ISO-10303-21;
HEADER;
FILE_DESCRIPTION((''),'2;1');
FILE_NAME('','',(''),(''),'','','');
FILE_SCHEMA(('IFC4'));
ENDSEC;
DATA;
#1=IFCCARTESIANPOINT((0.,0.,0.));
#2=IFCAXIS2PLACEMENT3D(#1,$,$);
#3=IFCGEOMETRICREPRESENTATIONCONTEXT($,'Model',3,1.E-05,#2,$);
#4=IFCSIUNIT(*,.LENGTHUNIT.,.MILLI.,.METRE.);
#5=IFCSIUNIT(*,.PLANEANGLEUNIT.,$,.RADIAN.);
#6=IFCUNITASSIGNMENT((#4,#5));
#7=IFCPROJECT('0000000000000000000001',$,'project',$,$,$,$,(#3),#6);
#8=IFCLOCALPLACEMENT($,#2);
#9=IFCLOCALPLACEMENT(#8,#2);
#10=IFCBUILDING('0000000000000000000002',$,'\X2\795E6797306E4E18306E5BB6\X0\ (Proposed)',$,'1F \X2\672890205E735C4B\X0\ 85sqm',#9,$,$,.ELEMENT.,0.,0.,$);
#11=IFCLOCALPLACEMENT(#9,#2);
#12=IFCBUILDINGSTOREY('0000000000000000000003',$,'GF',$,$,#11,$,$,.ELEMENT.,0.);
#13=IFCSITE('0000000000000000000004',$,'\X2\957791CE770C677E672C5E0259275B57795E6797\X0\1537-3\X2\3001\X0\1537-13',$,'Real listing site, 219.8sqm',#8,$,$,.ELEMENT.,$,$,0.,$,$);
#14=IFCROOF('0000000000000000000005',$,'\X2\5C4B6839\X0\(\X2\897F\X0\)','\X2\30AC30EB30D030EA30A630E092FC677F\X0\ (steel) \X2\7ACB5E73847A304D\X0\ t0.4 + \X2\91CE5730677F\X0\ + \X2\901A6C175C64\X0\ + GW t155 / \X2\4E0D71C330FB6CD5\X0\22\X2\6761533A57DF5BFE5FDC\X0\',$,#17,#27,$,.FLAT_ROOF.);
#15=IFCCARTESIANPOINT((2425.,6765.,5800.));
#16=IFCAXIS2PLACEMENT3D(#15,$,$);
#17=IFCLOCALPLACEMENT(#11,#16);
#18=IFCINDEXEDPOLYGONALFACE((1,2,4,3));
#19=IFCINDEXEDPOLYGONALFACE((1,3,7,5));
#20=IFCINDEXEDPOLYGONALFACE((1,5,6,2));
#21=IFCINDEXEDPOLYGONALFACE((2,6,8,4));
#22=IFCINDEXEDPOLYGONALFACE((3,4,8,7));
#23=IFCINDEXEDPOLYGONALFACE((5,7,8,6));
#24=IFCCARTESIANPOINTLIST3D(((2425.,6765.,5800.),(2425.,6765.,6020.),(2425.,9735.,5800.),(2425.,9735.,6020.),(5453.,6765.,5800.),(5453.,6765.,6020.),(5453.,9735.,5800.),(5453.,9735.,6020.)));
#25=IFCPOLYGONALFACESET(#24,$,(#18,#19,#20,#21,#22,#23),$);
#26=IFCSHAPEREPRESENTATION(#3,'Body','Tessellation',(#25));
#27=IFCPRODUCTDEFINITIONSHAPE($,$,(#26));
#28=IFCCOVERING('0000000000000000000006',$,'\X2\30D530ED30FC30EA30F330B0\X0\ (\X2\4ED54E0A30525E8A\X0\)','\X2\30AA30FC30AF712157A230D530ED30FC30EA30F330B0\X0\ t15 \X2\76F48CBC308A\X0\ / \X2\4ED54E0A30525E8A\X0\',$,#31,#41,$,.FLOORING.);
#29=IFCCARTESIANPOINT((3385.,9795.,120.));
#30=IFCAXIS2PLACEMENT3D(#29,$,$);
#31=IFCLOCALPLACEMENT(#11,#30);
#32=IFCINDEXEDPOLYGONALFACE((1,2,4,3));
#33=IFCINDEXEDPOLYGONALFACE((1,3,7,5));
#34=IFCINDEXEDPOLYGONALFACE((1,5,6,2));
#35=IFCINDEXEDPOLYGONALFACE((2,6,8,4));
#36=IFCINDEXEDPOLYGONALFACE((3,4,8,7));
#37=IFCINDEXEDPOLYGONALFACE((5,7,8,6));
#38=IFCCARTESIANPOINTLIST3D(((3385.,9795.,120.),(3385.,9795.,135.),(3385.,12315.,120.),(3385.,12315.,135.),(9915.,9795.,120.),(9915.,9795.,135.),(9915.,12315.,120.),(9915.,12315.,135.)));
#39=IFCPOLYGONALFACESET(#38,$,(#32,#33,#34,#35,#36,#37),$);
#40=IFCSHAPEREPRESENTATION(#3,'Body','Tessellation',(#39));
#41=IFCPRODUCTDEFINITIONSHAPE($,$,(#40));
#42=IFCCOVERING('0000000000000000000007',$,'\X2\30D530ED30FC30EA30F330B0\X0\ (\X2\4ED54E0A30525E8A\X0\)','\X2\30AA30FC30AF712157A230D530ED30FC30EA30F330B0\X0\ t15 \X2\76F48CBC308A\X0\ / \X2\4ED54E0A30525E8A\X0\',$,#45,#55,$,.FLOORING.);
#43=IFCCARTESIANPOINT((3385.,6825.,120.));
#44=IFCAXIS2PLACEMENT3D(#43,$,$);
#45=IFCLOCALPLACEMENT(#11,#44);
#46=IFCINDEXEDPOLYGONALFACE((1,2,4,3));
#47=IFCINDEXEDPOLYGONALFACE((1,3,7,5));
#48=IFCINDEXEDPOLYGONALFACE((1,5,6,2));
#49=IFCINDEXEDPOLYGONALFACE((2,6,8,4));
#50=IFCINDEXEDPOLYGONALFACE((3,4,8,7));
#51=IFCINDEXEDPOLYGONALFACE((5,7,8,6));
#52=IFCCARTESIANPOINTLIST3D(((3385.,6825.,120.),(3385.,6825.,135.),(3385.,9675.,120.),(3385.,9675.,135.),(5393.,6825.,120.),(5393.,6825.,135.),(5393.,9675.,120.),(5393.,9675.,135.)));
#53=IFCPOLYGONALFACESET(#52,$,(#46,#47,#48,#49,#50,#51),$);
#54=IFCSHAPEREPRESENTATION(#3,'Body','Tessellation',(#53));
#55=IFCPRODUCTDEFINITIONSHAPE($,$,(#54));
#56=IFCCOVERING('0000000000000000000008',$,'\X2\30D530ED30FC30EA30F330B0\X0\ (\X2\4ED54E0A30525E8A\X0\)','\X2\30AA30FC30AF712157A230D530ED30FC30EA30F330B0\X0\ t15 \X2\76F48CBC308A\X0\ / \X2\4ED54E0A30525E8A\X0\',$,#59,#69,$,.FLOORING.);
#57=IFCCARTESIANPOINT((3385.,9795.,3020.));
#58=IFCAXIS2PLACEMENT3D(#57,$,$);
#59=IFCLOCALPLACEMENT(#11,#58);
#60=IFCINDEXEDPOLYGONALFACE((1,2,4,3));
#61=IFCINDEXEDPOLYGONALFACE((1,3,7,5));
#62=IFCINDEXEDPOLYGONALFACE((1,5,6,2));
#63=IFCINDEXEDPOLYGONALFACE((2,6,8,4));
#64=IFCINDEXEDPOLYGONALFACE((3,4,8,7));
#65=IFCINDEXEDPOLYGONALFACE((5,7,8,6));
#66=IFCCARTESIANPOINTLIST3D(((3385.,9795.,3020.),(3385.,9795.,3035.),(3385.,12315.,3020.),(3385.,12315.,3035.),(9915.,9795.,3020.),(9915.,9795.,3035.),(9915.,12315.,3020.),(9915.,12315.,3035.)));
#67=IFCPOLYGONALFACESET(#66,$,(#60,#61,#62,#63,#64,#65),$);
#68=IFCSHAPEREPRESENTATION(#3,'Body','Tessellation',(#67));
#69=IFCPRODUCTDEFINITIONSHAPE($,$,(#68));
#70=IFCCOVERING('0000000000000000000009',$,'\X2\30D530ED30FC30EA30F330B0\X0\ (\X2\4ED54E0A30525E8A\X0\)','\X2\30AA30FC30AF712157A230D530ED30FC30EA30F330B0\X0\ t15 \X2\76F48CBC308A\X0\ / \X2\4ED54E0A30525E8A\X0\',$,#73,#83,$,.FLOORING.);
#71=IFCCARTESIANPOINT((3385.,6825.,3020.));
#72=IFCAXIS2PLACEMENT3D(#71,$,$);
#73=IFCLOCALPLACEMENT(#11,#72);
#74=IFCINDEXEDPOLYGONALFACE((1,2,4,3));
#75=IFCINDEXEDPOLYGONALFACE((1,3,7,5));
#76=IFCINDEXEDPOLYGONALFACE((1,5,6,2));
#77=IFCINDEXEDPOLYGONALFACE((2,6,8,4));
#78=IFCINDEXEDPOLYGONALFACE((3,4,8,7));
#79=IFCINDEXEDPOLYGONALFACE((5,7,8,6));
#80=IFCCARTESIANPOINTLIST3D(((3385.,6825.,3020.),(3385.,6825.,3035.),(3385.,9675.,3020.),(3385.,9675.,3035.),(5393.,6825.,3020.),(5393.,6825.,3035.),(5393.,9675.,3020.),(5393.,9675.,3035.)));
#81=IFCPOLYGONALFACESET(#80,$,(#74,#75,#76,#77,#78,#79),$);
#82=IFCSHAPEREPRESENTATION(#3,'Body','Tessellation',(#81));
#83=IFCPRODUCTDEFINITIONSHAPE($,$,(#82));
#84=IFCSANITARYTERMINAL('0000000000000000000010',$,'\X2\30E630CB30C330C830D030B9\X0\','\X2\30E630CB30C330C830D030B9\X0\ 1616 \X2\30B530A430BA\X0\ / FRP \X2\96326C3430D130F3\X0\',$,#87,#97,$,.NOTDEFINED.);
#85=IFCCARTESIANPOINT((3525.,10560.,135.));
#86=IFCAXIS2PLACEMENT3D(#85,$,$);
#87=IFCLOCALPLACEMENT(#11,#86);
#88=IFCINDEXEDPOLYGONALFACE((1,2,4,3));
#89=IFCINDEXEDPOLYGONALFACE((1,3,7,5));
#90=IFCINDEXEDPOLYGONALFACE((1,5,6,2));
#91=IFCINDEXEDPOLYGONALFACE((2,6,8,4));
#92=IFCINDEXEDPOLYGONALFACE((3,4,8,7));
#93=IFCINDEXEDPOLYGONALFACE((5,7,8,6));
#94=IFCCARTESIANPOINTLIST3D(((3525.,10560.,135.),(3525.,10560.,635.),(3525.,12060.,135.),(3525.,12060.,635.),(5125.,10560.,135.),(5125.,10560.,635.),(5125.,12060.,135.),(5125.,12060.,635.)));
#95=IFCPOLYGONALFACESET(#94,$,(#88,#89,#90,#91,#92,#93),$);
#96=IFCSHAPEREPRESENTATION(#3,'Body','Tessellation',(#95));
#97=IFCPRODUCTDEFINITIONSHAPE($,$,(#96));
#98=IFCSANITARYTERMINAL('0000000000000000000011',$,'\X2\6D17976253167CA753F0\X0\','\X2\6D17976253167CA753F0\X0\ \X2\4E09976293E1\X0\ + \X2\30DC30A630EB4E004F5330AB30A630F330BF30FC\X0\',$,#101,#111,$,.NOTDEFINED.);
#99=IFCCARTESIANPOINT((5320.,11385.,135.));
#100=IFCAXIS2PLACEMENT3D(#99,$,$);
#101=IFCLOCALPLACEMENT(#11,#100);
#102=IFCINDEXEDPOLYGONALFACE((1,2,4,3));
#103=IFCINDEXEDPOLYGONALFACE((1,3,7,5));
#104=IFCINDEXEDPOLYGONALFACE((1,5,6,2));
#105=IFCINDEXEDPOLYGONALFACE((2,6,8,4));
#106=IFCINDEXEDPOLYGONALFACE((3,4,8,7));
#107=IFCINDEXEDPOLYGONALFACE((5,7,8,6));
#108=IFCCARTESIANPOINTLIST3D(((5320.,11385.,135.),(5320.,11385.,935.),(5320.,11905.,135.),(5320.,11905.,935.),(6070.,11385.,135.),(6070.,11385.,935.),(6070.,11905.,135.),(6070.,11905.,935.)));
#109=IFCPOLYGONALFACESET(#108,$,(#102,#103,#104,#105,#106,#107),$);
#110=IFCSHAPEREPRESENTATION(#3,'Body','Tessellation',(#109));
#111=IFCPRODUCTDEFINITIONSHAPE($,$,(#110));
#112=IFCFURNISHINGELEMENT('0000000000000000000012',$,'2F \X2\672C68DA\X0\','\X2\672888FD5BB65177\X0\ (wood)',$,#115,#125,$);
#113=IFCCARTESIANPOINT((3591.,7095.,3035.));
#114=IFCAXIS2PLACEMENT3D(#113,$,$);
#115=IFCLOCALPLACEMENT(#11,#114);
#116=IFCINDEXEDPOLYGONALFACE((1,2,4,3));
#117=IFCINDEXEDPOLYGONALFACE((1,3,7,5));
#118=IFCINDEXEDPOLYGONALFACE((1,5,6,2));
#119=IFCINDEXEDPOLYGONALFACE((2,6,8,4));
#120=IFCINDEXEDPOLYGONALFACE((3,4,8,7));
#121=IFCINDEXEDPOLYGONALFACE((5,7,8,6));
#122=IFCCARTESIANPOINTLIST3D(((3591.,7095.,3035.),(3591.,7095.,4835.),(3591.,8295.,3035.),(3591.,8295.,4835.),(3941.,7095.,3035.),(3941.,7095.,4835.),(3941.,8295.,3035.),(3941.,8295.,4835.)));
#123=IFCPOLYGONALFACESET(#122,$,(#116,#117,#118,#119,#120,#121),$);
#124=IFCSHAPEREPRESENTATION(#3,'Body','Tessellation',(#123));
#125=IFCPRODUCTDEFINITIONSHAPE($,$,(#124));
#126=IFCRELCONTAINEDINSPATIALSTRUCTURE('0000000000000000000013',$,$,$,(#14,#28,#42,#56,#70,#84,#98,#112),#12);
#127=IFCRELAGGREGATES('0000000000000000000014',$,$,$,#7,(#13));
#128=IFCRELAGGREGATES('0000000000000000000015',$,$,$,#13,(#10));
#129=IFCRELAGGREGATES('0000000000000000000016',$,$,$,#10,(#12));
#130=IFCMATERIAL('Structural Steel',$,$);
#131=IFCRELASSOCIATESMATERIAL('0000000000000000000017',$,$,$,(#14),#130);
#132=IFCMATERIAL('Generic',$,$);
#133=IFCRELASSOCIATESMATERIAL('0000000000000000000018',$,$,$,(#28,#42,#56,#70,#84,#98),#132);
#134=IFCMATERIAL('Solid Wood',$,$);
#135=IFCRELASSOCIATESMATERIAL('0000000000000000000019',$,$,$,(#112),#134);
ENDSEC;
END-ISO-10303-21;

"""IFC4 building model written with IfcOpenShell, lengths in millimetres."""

from ifc_helpers import new_model, si_unit, frame, frame_2d, origin, place, context, project, spatial, rectangle, extrude, material, element, save


model = new_model("IFC4")

# Units and contexts
model_context = context("Model", 3, precision=1e-05, world=origin())
ifc_project = project(units=[si_unit("LENGTHUNIT", "METRE", prefix="MILLI"), si_unit("PLANEANGLEUNIT", "RADIAN")], contexts=[model_context])

# Site, building, storey
site_placement = place(None, origin())
site = spatial("IfcSite", under=ifc_project, at=site_placement, Name="長野県松本市大字神林1537-3、1537-13", ObjectType="Real listing site, 219.8sqm", CompositionType="ELEMENT", RefElevation=0.0)
building_placement = place(site_placement, origin())
building = spatial("IfcBuilding", under=site, at=building_placement, Name="神林の丘の家 (Proposed)", ObjectType="1F 木造平屋 85sqm", CompositionType="ELEMENT", ElevationOfRefHeight=0.0, ElevationOfTerrain=0.0)
storey_placement = place(building_placement, origin())
storey = spatial("IfcBuildingStorey", under=building, at=storey_placement, Name="GF", CompositionType="ELEMENT", Elevation=0.0)

# Shared definitions
ifc_material_1 = material(Name="Solid Wood")

# Roof
ifc_material_2 = material(Name="Structural Steel")
roof_placement = place(storey_placement, frame((2425.0, 6765.0, 5800.0)))
element("IfcRoof", 1, at=roof_placement, inside=storey, material=ifc_material_2, Name="屋根(西)", Description="ガルバリウム鋼板 (steel) 立平葺き t0.4 + 野地板 + 通気層 + GW t155 / 不燃・法22条区域対応", PredefinedType="FLAT_ROOF", context=model_context, shape_type="SweptSolid", body=[
    extrude(rectangle(XDim=3028.0, YDim=2970.0, at=frame_2d((1514.0, 1485.0))), frame((2425.0, 6765.0, 5800.0)), (0.0, 0.0, 1.0), 220.0),
])

# Coverings
ifc_material_3 = material(Name="Generic")
covering_1_placement = place(storey_placement, frame((3385.0, 9795.0, 120.0)))
element("IfcCovering", 2, at=covering_1_placement, inside=storey, material=ifc_material_3, Name="フローリング (仕上げ床)", Description="オーク無垢フローリング t15 直貼り / 仕上げ床", PredefinedType="FLOORING", context=model_context, shape_type="SweptSolid", body=[
    extrude(rectangle(XDim=6530.0, YDim=2520.0, at=frame_2d((3265.0, 1260.0))), frame((3385.0, 9795.0, 120.0)), (0.0, 0.0, 1.0), 15.0),
])
covering_2_placement = place(storey_placement, frame((3385.0, 6825.0, 120.0)))
element("IfcCovering", 3, at=covering_2_placement, inside=storey, material=ifc_material_3, Name="フローリング (仕上げ床)", Description="オーク無垢フローリング t15 直貼り / 仕上げ床", PredefinedType="FLOORING", context=model_context, shape_type="SweptSolid", body=[
    extrude(rectangle(XDim=2008.0, YDim=2850.0, at=frame_2d((1004.0, 1425.0))), frame((3385.0, 6825.0, 120.0)), (0.0, 0.0, 1.0), 15.0),
])
covering_3_placement = place(storey_placement, frame((3385.0, 9795.0, 3020.0)))
element("IfcCovering", 4, at=covering_3_placement, inside=storey, material=ifc_material_3, Name="フローリング (仕上げ床)", Description="オーク無垢フローリング t15 直貼り / 仕上げ床", PredefinedType="FLOORING", context=model_context, shape_type="SweptSolid", body=[
    extrude(rectangle(XDim=6530.0, YDim=2520.0, at=frame_2d((3265.0, 1260.0))), frame((3385.0, 9795.0, 3020.0)), (0.0, 0.0, 1.0), 15.0),
])
covering_4_placement = place(storey_placement, frame((3385.0, 6825.0, 3020.0)))
element("IfcCovering", 5, at=covering_4_placement, inside=storey, material=ifc_material_3, Name="フローリング (仕上げ床)", Description="オーク無垢フローリング t15 直貼り / 仕上げ床", PredefinedType="FLOORING", context=model_context, shape_type="SweptSolid", body=[
    extrude(rectangle(XDim=2008.0, YDim=2850.0, at=frame_2d((1004.0, 1425.0))), frame((3385.0, 6825.0, 3020.0)), (0.0, 0.0, 1.0), 15.0),
])

# Sanitary terminals
sanitary_terminal_1_placement = place(storey_placement, frame((3525.0, 10560.0, 135.0)))
element("IfcSanitaryTerminal", 6, at=sanitary_terminal_1_placement, inside=storey, material=ifc_material_3, Name="ユニットバス", Description="ユニットバス 1616 サイズ / FRP 防水パン", PredefinedType="NOTDEFINED", context=model_context, shape_type="SweptSolid", body=[
    extrude(rectangle(XDim=1600.0, YDim=1500.0, at=frame_2d((800.0, 750.0))), frame((3525.0, 10560.0, 135.0)), (0.0, 0.0, 1.0), 500.0),
])
sanitary_terminal_2_placement = place(storey_placement, frame((5320.0, 11385.0, 135.0)))
element("IfcSanitaryTerminal", 7, at=sanitary_terminal_2_placement, inside=storey, material=ifc_material_3, Name="洗面化粧台", Description="洗面化粧台 三面鏡 + ボウル一体カウンター", PredefinedType="NOTDEFINED", context=model_context, shape_type="SweptSolid", body=[
    extrude(rectangle(XDim=750.0, YDim=520.0, at=frame_2d((375.0, 260.0))), frame((5320.0, 11385.0, 135.0)), (0.0, 0.0, 1.0), 800.0),
])

# Furnishing element
furnishing_placement = place(storey_placement, frame((3591.0, 7095.0, 3035.0)))
element("IfcFurnishingElement", 8, at=furnishing_placement, inside=storey, material=ifc_material_1, Name="2F 本棚", Description="木製家具 (wood)", context=model_context, shape_type="SweptSolid", body=[
    extrude(rectangle(XDim=350.0, YDim=1200.0, at=frame_2d((175.0, 600.0))), frame((3591.0, 7095.0, 3035.0)), (0.0, 0.0, 1.0), 1800.0),
])

save(model, "model.ifc")
